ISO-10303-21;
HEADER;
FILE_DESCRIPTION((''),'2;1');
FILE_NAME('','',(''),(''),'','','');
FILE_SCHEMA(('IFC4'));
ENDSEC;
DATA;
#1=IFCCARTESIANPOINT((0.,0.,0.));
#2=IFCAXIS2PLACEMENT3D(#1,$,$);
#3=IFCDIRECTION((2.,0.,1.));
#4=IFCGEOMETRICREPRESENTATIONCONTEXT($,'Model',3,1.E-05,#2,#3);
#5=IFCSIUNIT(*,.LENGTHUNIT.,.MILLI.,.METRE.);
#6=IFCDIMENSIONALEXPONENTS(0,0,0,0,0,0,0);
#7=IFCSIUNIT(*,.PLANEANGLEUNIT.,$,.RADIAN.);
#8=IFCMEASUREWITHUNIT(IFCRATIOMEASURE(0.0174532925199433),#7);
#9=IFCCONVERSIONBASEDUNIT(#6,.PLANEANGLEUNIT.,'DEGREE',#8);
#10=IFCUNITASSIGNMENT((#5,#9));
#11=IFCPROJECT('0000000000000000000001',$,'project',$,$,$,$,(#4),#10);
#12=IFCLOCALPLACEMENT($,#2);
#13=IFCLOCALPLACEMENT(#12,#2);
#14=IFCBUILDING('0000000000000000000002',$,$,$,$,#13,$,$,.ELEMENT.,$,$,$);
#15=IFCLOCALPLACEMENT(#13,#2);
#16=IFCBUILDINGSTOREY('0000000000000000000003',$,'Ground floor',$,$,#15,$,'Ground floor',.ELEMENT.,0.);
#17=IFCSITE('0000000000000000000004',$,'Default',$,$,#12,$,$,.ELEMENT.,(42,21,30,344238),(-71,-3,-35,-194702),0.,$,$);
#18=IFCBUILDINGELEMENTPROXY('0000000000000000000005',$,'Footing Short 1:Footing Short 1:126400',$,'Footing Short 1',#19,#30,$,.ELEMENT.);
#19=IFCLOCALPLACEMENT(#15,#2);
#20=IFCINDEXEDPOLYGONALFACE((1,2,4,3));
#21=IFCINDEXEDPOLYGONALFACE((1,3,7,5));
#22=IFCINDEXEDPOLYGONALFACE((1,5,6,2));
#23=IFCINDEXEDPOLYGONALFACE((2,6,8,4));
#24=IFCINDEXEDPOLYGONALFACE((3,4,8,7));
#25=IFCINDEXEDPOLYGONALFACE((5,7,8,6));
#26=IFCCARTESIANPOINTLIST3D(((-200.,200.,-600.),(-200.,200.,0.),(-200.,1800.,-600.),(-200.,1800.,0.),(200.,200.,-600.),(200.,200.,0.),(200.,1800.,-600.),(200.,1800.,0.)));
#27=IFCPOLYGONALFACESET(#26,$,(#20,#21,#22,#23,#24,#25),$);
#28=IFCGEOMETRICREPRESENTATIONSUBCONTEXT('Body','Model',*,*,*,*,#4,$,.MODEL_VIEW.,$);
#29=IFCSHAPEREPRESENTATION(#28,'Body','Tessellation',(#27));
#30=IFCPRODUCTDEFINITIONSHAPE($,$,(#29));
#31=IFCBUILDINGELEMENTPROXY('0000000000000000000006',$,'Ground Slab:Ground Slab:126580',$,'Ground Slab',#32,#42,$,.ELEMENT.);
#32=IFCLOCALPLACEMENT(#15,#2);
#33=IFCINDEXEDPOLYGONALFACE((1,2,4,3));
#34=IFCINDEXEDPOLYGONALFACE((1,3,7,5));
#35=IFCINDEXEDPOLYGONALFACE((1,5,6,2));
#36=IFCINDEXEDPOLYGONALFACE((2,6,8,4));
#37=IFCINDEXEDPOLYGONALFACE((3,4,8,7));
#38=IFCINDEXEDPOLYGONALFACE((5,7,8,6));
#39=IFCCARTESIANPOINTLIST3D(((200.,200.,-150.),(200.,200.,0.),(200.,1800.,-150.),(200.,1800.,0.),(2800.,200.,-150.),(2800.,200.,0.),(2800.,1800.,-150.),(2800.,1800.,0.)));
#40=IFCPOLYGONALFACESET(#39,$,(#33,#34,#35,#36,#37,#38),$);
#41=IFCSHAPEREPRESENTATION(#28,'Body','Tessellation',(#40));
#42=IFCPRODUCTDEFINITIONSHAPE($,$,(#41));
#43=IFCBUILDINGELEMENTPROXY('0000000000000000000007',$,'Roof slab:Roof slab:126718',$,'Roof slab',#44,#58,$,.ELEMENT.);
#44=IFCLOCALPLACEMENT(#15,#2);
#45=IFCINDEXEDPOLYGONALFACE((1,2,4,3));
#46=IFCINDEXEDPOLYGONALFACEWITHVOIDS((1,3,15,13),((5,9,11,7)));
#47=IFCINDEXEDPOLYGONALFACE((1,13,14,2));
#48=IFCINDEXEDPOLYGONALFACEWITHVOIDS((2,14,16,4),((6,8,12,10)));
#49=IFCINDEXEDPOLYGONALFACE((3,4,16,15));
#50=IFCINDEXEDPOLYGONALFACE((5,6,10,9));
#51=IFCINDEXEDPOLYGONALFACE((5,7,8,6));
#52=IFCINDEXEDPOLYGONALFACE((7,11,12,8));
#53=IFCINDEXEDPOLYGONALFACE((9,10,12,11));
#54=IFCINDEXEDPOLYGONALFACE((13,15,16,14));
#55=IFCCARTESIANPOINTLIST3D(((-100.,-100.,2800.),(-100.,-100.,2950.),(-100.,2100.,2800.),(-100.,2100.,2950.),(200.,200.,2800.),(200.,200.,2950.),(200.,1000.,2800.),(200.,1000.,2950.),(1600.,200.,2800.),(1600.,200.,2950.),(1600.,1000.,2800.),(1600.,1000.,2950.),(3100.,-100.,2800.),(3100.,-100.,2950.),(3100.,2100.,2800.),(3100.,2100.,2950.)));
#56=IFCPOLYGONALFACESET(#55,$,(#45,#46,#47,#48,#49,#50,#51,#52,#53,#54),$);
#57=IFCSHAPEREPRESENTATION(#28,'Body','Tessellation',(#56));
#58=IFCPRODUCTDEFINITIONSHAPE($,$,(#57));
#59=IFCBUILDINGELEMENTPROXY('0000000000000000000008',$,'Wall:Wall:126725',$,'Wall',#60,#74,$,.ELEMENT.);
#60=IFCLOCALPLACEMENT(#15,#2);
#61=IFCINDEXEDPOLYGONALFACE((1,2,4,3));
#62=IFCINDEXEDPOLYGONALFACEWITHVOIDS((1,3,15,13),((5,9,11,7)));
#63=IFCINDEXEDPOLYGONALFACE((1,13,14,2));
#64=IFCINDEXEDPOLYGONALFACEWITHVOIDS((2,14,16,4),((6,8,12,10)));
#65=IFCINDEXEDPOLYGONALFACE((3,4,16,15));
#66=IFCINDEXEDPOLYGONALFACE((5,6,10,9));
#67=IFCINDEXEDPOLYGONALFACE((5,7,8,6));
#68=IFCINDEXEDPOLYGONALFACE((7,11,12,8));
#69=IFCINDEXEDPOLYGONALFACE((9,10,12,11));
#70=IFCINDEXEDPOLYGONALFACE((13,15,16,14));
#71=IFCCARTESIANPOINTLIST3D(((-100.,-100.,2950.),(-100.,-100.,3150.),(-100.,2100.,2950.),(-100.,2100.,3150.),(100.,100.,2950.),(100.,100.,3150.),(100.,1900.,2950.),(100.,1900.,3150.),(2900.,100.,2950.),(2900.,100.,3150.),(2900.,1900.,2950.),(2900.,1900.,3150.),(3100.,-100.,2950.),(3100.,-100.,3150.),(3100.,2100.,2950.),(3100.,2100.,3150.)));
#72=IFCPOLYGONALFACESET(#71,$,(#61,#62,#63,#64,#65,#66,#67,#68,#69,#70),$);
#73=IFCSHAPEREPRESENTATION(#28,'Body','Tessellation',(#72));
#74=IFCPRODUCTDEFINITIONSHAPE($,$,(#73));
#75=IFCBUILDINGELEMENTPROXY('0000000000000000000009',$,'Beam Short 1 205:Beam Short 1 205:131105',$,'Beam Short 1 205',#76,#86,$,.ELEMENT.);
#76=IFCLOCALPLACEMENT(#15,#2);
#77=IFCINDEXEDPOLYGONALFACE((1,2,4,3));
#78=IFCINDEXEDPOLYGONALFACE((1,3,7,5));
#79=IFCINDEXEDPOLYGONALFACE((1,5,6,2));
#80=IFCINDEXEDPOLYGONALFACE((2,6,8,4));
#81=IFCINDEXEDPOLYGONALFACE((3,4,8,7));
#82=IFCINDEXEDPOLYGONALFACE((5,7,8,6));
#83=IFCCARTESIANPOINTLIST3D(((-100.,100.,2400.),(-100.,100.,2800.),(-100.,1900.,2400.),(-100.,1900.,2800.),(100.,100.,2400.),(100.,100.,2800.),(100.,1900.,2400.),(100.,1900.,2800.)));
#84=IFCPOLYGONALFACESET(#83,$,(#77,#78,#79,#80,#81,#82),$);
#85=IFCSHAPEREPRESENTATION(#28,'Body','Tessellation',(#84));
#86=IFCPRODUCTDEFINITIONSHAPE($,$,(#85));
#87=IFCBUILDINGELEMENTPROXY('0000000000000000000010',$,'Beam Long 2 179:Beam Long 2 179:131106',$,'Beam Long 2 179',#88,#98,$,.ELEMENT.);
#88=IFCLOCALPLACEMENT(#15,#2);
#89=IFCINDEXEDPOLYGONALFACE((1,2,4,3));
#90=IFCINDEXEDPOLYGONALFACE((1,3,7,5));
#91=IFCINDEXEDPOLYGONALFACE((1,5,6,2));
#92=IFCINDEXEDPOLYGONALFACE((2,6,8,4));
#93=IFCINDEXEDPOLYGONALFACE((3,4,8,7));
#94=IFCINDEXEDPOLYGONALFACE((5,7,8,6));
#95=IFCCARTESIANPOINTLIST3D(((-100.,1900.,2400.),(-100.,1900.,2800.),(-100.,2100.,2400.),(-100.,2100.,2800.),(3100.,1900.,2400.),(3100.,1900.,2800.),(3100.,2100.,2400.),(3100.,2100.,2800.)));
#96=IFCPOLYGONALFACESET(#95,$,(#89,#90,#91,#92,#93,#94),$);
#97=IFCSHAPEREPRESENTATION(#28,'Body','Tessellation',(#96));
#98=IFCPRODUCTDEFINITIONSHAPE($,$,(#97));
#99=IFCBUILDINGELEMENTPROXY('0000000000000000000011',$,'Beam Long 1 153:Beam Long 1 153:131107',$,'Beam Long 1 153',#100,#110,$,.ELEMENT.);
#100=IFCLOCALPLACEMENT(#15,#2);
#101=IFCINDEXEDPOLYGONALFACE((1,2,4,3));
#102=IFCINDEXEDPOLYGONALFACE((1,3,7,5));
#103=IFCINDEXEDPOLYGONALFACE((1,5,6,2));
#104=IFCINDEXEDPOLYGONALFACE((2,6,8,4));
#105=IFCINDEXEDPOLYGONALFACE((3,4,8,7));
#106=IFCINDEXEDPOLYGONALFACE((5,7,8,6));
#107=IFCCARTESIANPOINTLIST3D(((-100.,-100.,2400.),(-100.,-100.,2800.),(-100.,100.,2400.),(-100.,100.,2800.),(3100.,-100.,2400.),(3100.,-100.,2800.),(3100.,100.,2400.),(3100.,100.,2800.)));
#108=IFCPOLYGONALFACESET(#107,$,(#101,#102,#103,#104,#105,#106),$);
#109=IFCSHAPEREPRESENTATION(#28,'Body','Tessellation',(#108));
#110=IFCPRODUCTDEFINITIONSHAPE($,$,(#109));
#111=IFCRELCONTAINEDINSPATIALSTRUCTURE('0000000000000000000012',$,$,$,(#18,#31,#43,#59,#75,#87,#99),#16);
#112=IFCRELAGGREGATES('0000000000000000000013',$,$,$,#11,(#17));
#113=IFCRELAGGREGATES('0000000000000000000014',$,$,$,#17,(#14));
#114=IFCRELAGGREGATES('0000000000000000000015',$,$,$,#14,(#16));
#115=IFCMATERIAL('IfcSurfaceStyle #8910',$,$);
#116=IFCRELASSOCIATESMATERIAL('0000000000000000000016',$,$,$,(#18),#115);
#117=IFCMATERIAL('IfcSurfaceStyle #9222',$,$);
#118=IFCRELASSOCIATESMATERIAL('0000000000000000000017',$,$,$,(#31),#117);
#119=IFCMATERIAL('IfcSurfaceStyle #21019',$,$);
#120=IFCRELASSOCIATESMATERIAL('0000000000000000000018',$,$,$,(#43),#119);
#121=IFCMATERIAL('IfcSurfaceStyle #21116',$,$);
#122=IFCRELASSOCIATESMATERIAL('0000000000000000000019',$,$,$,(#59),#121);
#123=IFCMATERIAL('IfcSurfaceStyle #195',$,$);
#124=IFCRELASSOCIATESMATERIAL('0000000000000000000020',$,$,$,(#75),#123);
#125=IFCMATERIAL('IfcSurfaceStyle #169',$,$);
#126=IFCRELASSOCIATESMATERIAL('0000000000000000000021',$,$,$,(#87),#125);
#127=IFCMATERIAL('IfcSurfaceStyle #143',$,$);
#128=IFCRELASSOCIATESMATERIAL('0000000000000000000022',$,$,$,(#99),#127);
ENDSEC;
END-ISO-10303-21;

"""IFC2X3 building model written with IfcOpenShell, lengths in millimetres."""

from ifc_helpers import new_model, entity, si_unit, converted_unit, direction, frame, origin, origin_2d_with_axis, place, context, subcontext, project, spatial, polyline, rectangle, outline, extrude, source, transform, mapped, material, element, save


model = new_model("IFC2X3")

# Units and contexts
model_context = context("Model", 3, precision=1e-05, world=origin(), true_north=direction((2.0, 0.0, 1.0)))
body_context = subcontext(model_context, "Body", "Model", "MODEL_VIEW")
ifc_project = project(units=[si_unit("LENGTHUNIT", "METRE", prefix="MILLI"), converted_unit("PLANEANGLEUNIT", "DEGREE", entity("IfcRatioMeasure", 0.0174532925199433), si_unit("PLANEANGLEUNIT", "RADIAN"), dimensions=[0, 0, 0, 0, 0, 0, 0])], contexts=[model_context])

# Site, building, storey
site_placement = place(None, origin())
site = spatial("IfcSite", under=ifc_project, at=site_placement, Name="Default", CompositionType="ELEMENT", RefLatitude=(42, 21, 30, 344238), RefLongitude=(-71, -3, -35, -194702), RefElevation=0.0)
building_placement = place(site_placement, origin())
building = spatial("IfcBuilding", under=site, at=building_placement, CompositionType="ELEMENT")
storey_placement = place(building_placement, origin())
storey = spatial("IfcBuildingStorey", under=building, at=storey_placement, Name="Ground floor", LongName="Ground floor", CompositionType="ELEMENT", Elevation=0.0)

# Building element proxies
ifc_material_1 = material(Name="IfcSurfaceStyle #8910")
shared_shape_1 = source(origin(), body_context, "Body", "SweptSolid", [
    extrude(rectangle(XDim=1600.0, YDim=400.0, at=origin_2d_with_axis()), frame((200.0, 800.0, 0.0), z_axis=(0.0, 0.0, 1.0), x_axis=(0.0, -1.0, 0.0)), (0.0, 0.0, 1.0), 600.0),
])
proxy_1_placement = place(building_placement, frame((-200.0, 200.0, -600.0)))
element("IfcBuildingElementProxy", 1, at=proxy_1_placement, inside=storey, material=ifc_material_1, Name="Footing Short 1:Footing Short 1:126400", ObjectType="Footing Short 1", CompositionType="ELEMENT", context=body_context, shape_type="MappedRepresentation", body=[
    mapped(shared_shape_1, transform((0.0, 0.0, 0.0), scale=1.0)),
])
ifc_material_2 = material(Name="IfcSurfaceStyle #9222")
shared_shape_2 = source(origin(), body_context, "Body", "SweptSolid", [
    extrude(rectangle(XDim=2600.0, YDim=1600.0, at=origin_2d_with_axis()), frame((1300.0, 800.0, 0.0)), (0.0, 0.0, 1.0), 150.0),
])
proxy_2_placement = place(building_placement, frame((200.0, 200.0, -150.0)))
element("IfcBuildingElementProxy", 2, at=proxy_2_placement, inside=storey, material=ifc_material_2, Name="Ground Slab:Ground Slab:126580", ObjectType="Ground Slab", CompositionType="ELEMENT", context=body_context, shape_type="MappedRepresentation", body=[
    mapped(shared_shape_2, transform((0.0, 0.0, 0.0), scale=1.0)),
])
ifc_material_3 = material(Name="IfcSurfaceStyle #21019")
shared_shape_3 = source(origin(), body_context, "Body", "SweptSolid", [
    extrude(outline(polyline([(-1600.0, -1100.0), (1600.0, -1100.0), (1600.0, 1100.0), (-1600.0, 1100.0), (-1600.0, -1100.0)]), holes=[polyline([(100.0, 0.0), (100.0, -800.0), (-1300.0, -800.0), (-1300.0, 0.0), (100.0, 0.0)])]), frame((1600.0, 1100.0, 0.0)), (0.0, 0.0, 1.0), 150.0),
])
proxy_3_placement = place(building_placement, frame((-100.0, -100.0, 2800.0)))
element("IfcBuildingElementProxy", 3, at=proxy_3_placement, inside=storey, material=ifc_material_3, Name="Roof slab:Roof slab:126718", ObjectType="Roof slab", CompositionType="ELEMENT", context=body_context, shape_type="MappedRepresentation", body=[
    mapped(shared_shape_3, transform((0.0, 0.0, 0.0), scale=1.0)),
])
ifc_material_4 = material(Name="IfcSurfaceStyle #21116")
shared_shape_4 = source(origin(), body_context, "Body", "SweptSolid", [
    extrude(outline(polyline([(-1600.0, -1100.0), (1600.0, -1100.0), (1600.0, 1100.0), (-1600.0, 1100.0), (-1600.0, -1100.0)]), holes=[polyline([(-1400.0, 900.0), (1400.0, 900.0), (1400.0, -900.0), (-1400.0, -900.0), (-1400.0, 900.0)])]), frame((1600.0, 1100.0, 0.0), z_axis=(0.0, 0.0, 1.0), x_axis=(-1.0, 0.0, 0.0)), (0.0, 0.0, 1.0), 200.0),
])
proxy_4_placement = place(building_placement, frame((-100.0, -100.0, 2950.0)))
element("IfcBuildingElementProxy", 4, at=proxy_4_placement, inside=storey, material=ifc_material_4, Name="Wall:Wall:126725", ObjectType="Wall", CompositionType="ELEMENT", context=body_context, shape_type="MappedRepresentation", body=[
    mapped(shared_shape_4, transform((0.0, 0.0, 0.0), scale=1.0)),
])
ifc_material_5 = material(Name="IfcSurfaceStyle #195")
shared_shape_5 = source(origin(), body_context, "Body", "SweptSolid", [
    extrude(rectangle(XDim=1800.0, YDim=200.0, at=origin_2d_with_axis()), frame((100.0, 900.0, 0.0), z_axis=(0.0, 0.0, 1.0), x_axis=(0.0, -1.0, 0.0)), (0.0, 0.0, 1.0), 400.0),
])
proxy_5_placement = place(building_placement, frame((-100.0, 100.0, 2400.0)))
element("IfcBuildingElementProxy", 5, at=proxy_5_placement, inside=storey, material=ifc_material_5, Name="Beam Short 1 205:Beam Short 1 205:131105", ObjectType="Beam Short 1 205", CompositionType="ELEMENT", context=body_context, shape_type="MappedRepresentation", body=[
    mapped(shared_shape_5, transform((0.0, 0.0, 0.0), scale=1.0)),
])
ifc_material_6 = material(Name="IfcSurfaceStyle #169")
shared_shape_6 = source(origin(), body_context, "Body", "SweptSolid", [
    extrude(rectangle(XDim=3200.0, YDim=200.0, at=origin_2d_with_axis()), frame((1600.0, 100.0, 0.0), z_axis=(0.0, 0.0, 1.0), x_axis=(-1.0, 0.0, 0.0)), (0.0, 0.0, 1.0), 400.0),
])
proxy_6_placement = place(building_placement, frame((-100.0, 1900.0, 2400.0)))
element("IfcBuildingElementProxy", 6, at=proxy_6_placement, inside=storey, material=ifc_material_6, Name="Beam Long 2 179:Beam Long 2 179:131106", ObjectType="Beam Long 2 179", CompositionType="ELEMENT", context=body_context, shape_type="MappedRepresentation", body=[
    mapped(shared_shape_6, transform((0.0, 0.0, 0.0), scale=1.0)),
])
ifc_material_7 = material(Name="IfcSurfaceStyle #143")
shared_shape_7 = source(origin(), body_context, "Body", "SweptSolid", [
    extrude(rectangle(XDim=3200.0, YDim=200.0, at=origin_2d_with_axis()), frame((1600.0, 100.0, 0.0), z_axis=(0.0, 0.0, 1.0), x_axis=(-1.0, 0.0, 0.0)), (0.0, 0.0, 1.0), 400.0),
])
proxy_7_placement = place(building_placement, frame((-100.0, -100.0, 2400.0)))
element("IfcBuildingElementProxy", 7, at=proxy_7_placement, inside=storey, material=ifc_material_7, Name="Beam Long 1 153:Beam Long 1 153:131107", ObjectType="Beam Long 1 153", CompositionType="ELEMENT", context=body_context, shape_type="MappedRepresentation", body=[
    mapped(shared_shape_7, transform((0.0, 0.0, 0.0), scale=1.0)),
])

save(model, "model.ifc")
